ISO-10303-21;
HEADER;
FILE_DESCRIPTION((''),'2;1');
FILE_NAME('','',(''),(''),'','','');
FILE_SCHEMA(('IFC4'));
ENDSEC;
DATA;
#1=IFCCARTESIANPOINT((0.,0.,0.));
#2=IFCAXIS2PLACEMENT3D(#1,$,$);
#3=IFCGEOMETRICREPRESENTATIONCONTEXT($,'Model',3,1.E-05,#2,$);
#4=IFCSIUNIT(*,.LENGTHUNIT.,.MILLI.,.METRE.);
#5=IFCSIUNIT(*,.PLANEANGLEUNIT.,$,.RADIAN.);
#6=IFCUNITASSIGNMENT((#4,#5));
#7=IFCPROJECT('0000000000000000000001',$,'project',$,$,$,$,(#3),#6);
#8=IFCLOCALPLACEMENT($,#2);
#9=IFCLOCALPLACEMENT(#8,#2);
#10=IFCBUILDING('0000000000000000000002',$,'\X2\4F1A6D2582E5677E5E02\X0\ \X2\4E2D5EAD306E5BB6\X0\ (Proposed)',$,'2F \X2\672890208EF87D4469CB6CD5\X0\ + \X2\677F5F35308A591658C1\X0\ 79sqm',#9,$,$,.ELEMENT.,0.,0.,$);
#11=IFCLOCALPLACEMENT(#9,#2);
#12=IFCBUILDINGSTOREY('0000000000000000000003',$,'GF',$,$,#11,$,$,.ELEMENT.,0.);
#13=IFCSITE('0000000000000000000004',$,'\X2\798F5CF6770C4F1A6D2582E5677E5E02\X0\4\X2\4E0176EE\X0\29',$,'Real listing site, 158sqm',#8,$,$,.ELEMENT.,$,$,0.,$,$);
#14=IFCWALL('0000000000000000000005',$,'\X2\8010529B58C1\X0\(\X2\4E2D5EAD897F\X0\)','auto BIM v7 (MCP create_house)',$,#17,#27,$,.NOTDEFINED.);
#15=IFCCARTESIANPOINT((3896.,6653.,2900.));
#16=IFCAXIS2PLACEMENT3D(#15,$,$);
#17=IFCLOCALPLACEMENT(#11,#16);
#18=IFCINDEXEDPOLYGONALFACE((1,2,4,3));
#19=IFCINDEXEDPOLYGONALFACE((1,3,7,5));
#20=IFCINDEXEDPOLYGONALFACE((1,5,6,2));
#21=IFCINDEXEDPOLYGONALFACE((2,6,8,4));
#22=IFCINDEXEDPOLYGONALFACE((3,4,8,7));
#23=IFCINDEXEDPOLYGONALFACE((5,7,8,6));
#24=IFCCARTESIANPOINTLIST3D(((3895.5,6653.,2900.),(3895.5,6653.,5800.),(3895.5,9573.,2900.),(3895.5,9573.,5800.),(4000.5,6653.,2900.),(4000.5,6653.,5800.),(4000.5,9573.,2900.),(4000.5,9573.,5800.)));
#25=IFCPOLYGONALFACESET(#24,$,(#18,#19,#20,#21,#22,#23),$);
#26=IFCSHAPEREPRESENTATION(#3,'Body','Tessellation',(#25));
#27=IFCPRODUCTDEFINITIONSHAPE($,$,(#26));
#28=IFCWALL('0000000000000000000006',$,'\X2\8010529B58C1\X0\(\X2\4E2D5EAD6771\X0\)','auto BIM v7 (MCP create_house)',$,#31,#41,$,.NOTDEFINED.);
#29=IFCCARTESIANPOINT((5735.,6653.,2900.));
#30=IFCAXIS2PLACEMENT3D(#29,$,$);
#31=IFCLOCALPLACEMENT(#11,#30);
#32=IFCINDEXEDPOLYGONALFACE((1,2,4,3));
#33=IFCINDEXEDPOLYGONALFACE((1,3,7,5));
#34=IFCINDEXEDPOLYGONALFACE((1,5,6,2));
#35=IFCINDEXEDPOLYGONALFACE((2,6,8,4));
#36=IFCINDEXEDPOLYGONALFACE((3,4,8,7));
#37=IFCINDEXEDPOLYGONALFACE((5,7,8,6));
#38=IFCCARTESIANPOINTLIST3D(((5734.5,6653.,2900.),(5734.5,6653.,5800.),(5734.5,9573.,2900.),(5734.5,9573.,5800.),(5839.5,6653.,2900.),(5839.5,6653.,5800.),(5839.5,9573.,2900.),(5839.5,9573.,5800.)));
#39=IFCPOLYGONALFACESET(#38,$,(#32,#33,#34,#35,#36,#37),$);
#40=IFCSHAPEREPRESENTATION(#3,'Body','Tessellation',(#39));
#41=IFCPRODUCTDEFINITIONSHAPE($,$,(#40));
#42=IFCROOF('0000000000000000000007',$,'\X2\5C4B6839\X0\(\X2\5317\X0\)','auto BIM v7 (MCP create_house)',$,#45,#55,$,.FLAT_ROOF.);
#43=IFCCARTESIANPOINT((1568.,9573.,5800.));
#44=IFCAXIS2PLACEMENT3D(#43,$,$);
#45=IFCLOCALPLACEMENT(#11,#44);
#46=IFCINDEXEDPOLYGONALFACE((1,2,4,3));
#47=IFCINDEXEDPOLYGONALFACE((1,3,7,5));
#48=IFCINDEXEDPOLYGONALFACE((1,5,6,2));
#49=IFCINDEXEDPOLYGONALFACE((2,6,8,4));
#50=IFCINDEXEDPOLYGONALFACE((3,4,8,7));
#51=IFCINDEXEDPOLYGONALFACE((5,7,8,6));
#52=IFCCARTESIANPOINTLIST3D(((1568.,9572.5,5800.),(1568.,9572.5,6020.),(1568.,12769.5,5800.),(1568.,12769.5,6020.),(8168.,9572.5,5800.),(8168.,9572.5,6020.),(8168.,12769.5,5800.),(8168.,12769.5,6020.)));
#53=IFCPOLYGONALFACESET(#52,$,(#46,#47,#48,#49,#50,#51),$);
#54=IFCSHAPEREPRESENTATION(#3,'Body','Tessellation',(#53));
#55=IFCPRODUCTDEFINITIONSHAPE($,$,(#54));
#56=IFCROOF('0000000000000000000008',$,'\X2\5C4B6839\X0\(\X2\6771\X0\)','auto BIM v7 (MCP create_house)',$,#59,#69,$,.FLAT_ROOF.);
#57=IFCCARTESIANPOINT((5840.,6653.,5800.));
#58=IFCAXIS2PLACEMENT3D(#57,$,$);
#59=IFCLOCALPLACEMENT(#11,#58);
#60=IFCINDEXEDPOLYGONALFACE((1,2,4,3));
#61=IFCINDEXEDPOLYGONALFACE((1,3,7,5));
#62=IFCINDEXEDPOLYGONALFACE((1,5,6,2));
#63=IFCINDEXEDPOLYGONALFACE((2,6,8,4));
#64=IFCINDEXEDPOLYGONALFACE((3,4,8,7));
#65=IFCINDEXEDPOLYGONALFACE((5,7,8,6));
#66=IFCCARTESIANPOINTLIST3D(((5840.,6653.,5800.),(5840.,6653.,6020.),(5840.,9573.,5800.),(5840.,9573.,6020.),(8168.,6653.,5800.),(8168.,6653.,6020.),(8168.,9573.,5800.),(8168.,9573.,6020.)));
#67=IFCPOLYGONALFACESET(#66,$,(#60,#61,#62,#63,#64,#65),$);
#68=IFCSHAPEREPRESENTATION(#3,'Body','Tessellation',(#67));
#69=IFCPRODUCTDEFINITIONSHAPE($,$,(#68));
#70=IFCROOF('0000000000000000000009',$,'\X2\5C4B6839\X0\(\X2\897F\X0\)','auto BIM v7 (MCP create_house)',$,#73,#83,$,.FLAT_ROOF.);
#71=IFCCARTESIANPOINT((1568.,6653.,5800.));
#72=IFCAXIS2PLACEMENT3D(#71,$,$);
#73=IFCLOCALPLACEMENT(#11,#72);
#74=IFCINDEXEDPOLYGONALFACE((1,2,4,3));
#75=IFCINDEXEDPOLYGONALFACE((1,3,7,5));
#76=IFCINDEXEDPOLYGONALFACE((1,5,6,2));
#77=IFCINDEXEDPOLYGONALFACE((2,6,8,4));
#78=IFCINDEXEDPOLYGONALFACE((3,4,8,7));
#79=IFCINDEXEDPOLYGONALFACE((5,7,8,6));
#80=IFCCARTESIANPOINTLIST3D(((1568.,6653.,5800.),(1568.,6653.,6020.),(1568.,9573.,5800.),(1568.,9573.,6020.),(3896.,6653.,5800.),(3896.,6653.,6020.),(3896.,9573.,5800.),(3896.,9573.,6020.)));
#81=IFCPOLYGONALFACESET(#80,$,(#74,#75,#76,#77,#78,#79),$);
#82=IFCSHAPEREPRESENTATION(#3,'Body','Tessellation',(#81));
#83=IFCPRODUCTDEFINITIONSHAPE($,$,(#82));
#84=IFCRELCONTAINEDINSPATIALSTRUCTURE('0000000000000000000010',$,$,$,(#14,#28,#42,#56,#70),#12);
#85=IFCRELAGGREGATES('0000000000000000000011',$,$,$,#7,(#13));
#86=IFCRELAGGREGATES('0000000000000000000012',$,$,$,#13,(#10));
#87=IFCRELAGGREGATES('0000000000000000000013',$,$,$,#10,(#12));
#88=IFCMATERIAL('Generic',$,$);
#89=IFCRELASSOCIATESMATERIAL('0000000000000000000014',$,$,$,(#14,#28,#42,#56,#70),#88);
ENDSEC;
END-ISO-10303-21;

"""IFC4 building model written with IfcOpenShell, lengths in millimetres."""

from ifc_helpers import new_model, si_unit, frame, frame_2d, origin, place, context, project, spatial, rectangle, extrude, material, element, save


model = new_model("IFC4")

# Units and contexts
model_context = context("Model", 3, precision=1e-05, world=origin())
ifc_project = project(units=[si_unit("LENGTHUNIT", "METRE", prefix="MILLI"), si_unit("PLANEANGLEUNIT", "RADIAN")], contexts=[model_context])

# Site, building, storey
site_placement = place(None, origin())
site = spatial("IfcSite", under=ifc_project, at=site_placement, Name="福島県会津若松市4丁目29", ObjectType="Real listing site, 158sqm", CompositionType="ELEMENT", RefElevation=0.0)
building_placement = place(site_placement, origin())
building = spatial("IfcBuilding", under=site, at=building_placement, Name="会津若松市 中庭の家 (Proposed)", ObjectType="2F 木造軸組構法 + 板張り外壁 79sqm", CompositionType="ELEMENT", ElevationOfRefHeight=0.0, ElevationOfTerrain=0.0)
storey_placement = place(building_placement, origin())
storey = spatial("IfcBuildingStorey", under=building, at=storey_placement, Name="GF", CompositionType="ELEMENT", Elevation=0.0)

# Shared definitions
ifc_material = material(Name="Generic")

# Walls
wall_1_placement = place(storey_placement, frame((3896.0, 6653.0, 2900.0)))
element("IfcWall", 1, at=wall_1_placement, inside=storey, material=ifc_material, Name="耐力壁(中庭西)", Description="auto BIM v7 (MCP create_house)", PredefinedType="NOTDEFINED", context=model_context, shape_type="SweptSolid", body=[
    extrude(rectangle(XDim=105.0, YDim=2920.0, at=frame_2d((52.0, 1460.0))), frame((3896.0, 6653.0, 2900.0)), (0.0, 0.0, 1.0), 2900.0),
])
wall_2_placement = place(storey_placement, frame((5735.0, 6653.0, 2900.0)))
element("IfcWall", 2, at=wall_2_placement, inside=storey, material=ifc_material, Name="耐力壁(中庭東)", Description="auto BIM v7 (MCP create_house)", PredefinedType="NOTDEFINED", context=model_context, shape_type="SweptSolid", body=[
    extrude(rectangle(XDim=105.0, YDim=2920.0, at=frame_2d((52.0, 1460.0))), frame((5735.0, 6653.0, 2900.0)), (0.0, 0.0, 1.0), 2900.0),
])

# Roofs
roof_1_placement = place(storey_placement, frame((1568.0, 9573.0, 5800.0)))
element("IfcRoof", 3, at=roof_1_placement, inside=storey, material=ifc_material, Name="屋根(北)", Description="auto BIM v7 (MCP create_house)", PredefinedType="FLAT_ROOF", context=model_context, shape_type="SweptSolid", body=[
    extrude(rectangle(XDim=6600.0, YDim=3197.0, at=frame_2d((3300.0, 1598.0))), frame((1568.0, 9573.0, 5800.0)), (0.0, 0.0, 1.0), 220.0),
])
roof_2_placement = place(storey_placement, frame((5840.0, 6653.0, 5800.0)))
element("IfcRoof", 4, at=roof_2_placement, inside=storey, material=ifc_material, Name="屋根(東)", Description="auto BIM v7 (MCP create_house)", PredefinedType="FLAT_ROOF", context=model_context, shape_type="SweptSolid", body=[
    extrude(rectangle(XDim=2328.0, YDim=2920.0, at=frame_2d((1164.0, 1460.0))), frame((5840.0, 6653.0, 5800.0)), (0.0, 0.0, 1.0), 220.0),
])
roof_3_placement = place(storey_placement, frame((1568.0, 6653.0, 5800.0)))
element("IfcRoof", 5, at=roof_3_placement, inside=storey, material=ifc_material, Name="屋根(西)", Description="auto BIM v7 (MCP create_house)", PredefinedType="FLAT_ROOF", context=model_context, shape_type="SweptSolid", body=[
    extrude(rectangle(XDim=2328.0, YDim=2920.0, at=frame_2d((1164.0, 1460.0))), frame((1568.0, 6653.0, 5800.0)), (0.0, 0.0, 1.0), 220.0),
])

save(model, "model.ifc")
